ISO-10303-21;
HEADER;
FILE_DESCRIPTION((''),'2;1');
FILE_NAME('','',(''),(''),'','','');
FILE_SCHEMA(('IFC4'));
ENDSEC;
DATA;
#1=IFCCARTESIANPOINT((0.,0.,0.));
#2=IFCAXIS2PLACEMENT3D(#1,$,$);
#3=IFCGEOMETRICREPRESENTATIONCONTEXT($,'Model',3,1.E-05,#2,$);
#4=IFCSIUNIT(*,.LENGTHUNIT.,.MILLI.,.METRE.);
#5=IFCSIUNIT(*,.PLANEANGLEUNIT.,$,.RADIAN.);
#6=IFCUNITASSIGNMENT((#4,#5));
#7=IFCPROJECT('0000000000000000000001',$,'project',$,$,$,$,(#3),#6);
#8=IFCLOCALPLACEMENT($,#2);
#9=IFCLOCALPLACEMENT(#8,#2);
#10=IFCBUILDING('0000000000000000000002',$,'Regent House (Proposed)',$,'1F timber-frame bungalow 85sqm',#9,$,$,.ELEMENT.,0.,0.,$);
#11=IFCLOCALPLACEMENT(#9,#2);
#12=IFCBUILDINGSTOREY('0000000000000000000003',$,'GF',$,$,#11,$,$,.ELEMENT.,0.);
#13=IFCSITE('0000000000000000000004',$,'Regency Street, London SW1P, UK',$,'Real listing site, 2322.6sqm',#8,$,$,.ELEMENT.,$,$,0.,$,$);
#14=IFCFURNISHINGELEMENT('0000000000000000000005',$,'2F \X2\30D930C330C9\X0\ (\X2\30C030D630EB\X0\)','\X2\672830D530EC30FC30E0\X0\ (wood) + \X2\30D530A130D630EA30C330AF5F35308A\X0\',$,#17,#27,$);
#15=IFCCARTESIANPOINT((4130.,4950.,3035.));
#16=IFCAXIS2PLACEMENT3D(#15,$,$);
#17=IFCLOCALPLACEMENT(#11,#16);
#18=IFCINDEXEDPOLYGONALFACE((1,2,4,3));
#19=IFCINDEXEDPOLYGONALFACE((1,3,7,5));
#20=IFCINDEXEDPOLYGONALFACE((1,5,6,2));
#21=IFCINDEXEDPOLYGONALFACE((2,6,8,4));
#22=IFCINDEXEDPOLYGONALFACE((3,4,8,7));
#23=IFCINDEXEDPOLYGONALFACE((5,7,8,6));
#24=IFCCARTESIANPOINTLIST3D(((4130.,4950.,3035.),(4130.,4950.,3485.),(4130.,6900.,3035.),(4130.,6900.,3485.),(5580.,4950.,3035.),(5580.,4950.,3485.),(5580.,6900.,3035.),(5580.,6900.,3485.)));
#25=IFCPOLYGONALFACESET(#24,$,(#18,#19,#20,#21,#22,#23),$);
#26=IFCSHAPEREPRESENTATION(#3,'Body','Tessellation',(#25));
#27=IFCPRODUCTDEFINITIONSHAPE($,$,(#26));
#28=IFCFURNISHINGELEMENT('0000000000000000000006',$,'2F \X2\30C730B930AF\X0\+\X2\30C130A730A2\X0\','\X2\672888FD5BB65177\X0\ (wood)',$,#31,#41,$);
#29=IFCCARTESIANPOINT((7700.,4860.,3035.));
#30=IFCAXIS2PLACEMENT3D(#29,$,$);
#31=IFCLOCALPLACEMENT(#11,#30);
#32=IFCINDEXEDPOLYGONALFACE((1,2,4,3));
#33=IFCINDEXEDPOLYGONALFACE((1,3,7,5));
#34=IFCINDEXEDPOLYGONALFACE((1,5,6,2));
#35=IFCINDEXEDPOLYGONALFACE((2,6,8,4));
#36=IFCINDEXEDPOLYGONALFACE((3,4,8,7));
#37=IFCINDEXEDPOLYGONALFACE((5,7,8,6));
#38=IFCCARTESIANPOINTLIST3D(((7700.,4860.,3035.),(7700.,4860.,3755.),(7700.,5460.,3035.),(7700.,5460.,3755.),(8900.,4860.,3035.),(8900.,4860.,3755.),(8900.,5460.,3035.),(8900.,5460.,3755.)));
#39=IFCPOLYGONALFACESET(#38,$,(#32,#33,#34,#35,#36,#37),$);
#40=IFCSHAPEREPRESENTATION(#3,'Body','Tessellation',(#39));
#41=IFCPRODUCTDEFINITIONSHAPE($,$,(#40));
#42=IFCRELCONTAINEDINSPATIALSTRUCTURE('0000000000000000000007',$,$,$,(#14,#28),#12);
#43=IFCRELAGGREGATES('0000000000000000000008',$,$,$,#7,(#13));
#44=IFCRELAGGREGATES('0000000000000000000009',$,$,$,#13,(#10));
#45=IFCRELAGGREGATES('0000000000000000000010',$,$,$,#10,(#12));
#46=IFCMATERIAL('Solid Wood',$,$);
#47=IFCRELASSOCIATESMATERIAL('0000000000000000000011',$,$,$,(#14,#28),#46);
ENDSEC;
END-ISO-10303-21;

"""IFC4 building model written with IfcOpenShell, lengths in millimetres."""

from ifc_helpers import new_model, si_unit, frame, frame_2d, origin, place, context, project, spatial, rectangle, extrude, material, element, save


model = new_model("IFC4")

# Units and contexts
model_context = context("Model", 3, precision=1e-05, world=origin())
ifc_project = project(units=[si_unit("LENGTHUNIT", "METRE", prefix="MILLI"), si_unit("PLANEANGLEUNIT", "RADIAN")], contexts=[model_context])

# Site, building, storey
site_placement = place(None, origin())
site = spatial("IfcSite", under=ifc_project, at=site_placement, Name="Regency Street, London SW1P, UK", ObjectType="Real listing site, 2322.6sqm", CompositionType="ELEMENT", RefElevation=0.0)
building_placement = place(site_placement, origin())
building = spatial("IfcBuilding", under=site, at=building_placement, Name="Regent House (Proposed)", ObjectType="1F timber-frame bungalow 85sqm", CompositionType="ELEMENT", ElevationOfRefHeight=0.0, ElevationOfTerrain=0.0)
storey_placement = place(building_placement, origin())
storey = spatial("IfcBuildingStorey", under=building, at=storey_placement, Name="GF", CompositionType="ELEMENT", Elevation=0.0)

# Shared definitions
ifc_material_1 = material(Name="Solid Wood")

# Furnishing elements
furnishing_1_placement = place(storey_placement, frame((4130.0, 4950.0, 3035.0)))
element("IfcFurnishingElement", 1, at=furnishing_1_placement, inside=storey, material=ifc_material_1, Name="2F ベッド (ダブル)", Description="木フレーム (wood) + ファブリック張り", context=model_context, shape_type="SweptSolid", body=[
    extrude(rectangle(XDim=1450.0, YDim=1950.0, at=frame_2d((725.0, 975.0))), frame((4130.0, 4950.0, 3035.0)), (0.0, 0.0, 1.0), 450.0),
])
furnishing_2_placement = place(storey_placement, frame((7700.0, 4860.0, 3035.0)))
element("IfcFurnishingElement", 2, at=furnishing_2_placement, inside=storey, material=ifc_material_1, Name="2F デスク+チェア", Description="木製家具 (wood)", context=model_context, shape_type="SweptSolid", body=[
    extrude(rectangle(XDim=1200.0, YDim=600.0, at=frame_2d((600.0, 300.0))), frame((7700.0, 4860.0, 3035.0)), (0.0, 0.0, 1.0), 720.0),
])

save(model, "model.ifc")
